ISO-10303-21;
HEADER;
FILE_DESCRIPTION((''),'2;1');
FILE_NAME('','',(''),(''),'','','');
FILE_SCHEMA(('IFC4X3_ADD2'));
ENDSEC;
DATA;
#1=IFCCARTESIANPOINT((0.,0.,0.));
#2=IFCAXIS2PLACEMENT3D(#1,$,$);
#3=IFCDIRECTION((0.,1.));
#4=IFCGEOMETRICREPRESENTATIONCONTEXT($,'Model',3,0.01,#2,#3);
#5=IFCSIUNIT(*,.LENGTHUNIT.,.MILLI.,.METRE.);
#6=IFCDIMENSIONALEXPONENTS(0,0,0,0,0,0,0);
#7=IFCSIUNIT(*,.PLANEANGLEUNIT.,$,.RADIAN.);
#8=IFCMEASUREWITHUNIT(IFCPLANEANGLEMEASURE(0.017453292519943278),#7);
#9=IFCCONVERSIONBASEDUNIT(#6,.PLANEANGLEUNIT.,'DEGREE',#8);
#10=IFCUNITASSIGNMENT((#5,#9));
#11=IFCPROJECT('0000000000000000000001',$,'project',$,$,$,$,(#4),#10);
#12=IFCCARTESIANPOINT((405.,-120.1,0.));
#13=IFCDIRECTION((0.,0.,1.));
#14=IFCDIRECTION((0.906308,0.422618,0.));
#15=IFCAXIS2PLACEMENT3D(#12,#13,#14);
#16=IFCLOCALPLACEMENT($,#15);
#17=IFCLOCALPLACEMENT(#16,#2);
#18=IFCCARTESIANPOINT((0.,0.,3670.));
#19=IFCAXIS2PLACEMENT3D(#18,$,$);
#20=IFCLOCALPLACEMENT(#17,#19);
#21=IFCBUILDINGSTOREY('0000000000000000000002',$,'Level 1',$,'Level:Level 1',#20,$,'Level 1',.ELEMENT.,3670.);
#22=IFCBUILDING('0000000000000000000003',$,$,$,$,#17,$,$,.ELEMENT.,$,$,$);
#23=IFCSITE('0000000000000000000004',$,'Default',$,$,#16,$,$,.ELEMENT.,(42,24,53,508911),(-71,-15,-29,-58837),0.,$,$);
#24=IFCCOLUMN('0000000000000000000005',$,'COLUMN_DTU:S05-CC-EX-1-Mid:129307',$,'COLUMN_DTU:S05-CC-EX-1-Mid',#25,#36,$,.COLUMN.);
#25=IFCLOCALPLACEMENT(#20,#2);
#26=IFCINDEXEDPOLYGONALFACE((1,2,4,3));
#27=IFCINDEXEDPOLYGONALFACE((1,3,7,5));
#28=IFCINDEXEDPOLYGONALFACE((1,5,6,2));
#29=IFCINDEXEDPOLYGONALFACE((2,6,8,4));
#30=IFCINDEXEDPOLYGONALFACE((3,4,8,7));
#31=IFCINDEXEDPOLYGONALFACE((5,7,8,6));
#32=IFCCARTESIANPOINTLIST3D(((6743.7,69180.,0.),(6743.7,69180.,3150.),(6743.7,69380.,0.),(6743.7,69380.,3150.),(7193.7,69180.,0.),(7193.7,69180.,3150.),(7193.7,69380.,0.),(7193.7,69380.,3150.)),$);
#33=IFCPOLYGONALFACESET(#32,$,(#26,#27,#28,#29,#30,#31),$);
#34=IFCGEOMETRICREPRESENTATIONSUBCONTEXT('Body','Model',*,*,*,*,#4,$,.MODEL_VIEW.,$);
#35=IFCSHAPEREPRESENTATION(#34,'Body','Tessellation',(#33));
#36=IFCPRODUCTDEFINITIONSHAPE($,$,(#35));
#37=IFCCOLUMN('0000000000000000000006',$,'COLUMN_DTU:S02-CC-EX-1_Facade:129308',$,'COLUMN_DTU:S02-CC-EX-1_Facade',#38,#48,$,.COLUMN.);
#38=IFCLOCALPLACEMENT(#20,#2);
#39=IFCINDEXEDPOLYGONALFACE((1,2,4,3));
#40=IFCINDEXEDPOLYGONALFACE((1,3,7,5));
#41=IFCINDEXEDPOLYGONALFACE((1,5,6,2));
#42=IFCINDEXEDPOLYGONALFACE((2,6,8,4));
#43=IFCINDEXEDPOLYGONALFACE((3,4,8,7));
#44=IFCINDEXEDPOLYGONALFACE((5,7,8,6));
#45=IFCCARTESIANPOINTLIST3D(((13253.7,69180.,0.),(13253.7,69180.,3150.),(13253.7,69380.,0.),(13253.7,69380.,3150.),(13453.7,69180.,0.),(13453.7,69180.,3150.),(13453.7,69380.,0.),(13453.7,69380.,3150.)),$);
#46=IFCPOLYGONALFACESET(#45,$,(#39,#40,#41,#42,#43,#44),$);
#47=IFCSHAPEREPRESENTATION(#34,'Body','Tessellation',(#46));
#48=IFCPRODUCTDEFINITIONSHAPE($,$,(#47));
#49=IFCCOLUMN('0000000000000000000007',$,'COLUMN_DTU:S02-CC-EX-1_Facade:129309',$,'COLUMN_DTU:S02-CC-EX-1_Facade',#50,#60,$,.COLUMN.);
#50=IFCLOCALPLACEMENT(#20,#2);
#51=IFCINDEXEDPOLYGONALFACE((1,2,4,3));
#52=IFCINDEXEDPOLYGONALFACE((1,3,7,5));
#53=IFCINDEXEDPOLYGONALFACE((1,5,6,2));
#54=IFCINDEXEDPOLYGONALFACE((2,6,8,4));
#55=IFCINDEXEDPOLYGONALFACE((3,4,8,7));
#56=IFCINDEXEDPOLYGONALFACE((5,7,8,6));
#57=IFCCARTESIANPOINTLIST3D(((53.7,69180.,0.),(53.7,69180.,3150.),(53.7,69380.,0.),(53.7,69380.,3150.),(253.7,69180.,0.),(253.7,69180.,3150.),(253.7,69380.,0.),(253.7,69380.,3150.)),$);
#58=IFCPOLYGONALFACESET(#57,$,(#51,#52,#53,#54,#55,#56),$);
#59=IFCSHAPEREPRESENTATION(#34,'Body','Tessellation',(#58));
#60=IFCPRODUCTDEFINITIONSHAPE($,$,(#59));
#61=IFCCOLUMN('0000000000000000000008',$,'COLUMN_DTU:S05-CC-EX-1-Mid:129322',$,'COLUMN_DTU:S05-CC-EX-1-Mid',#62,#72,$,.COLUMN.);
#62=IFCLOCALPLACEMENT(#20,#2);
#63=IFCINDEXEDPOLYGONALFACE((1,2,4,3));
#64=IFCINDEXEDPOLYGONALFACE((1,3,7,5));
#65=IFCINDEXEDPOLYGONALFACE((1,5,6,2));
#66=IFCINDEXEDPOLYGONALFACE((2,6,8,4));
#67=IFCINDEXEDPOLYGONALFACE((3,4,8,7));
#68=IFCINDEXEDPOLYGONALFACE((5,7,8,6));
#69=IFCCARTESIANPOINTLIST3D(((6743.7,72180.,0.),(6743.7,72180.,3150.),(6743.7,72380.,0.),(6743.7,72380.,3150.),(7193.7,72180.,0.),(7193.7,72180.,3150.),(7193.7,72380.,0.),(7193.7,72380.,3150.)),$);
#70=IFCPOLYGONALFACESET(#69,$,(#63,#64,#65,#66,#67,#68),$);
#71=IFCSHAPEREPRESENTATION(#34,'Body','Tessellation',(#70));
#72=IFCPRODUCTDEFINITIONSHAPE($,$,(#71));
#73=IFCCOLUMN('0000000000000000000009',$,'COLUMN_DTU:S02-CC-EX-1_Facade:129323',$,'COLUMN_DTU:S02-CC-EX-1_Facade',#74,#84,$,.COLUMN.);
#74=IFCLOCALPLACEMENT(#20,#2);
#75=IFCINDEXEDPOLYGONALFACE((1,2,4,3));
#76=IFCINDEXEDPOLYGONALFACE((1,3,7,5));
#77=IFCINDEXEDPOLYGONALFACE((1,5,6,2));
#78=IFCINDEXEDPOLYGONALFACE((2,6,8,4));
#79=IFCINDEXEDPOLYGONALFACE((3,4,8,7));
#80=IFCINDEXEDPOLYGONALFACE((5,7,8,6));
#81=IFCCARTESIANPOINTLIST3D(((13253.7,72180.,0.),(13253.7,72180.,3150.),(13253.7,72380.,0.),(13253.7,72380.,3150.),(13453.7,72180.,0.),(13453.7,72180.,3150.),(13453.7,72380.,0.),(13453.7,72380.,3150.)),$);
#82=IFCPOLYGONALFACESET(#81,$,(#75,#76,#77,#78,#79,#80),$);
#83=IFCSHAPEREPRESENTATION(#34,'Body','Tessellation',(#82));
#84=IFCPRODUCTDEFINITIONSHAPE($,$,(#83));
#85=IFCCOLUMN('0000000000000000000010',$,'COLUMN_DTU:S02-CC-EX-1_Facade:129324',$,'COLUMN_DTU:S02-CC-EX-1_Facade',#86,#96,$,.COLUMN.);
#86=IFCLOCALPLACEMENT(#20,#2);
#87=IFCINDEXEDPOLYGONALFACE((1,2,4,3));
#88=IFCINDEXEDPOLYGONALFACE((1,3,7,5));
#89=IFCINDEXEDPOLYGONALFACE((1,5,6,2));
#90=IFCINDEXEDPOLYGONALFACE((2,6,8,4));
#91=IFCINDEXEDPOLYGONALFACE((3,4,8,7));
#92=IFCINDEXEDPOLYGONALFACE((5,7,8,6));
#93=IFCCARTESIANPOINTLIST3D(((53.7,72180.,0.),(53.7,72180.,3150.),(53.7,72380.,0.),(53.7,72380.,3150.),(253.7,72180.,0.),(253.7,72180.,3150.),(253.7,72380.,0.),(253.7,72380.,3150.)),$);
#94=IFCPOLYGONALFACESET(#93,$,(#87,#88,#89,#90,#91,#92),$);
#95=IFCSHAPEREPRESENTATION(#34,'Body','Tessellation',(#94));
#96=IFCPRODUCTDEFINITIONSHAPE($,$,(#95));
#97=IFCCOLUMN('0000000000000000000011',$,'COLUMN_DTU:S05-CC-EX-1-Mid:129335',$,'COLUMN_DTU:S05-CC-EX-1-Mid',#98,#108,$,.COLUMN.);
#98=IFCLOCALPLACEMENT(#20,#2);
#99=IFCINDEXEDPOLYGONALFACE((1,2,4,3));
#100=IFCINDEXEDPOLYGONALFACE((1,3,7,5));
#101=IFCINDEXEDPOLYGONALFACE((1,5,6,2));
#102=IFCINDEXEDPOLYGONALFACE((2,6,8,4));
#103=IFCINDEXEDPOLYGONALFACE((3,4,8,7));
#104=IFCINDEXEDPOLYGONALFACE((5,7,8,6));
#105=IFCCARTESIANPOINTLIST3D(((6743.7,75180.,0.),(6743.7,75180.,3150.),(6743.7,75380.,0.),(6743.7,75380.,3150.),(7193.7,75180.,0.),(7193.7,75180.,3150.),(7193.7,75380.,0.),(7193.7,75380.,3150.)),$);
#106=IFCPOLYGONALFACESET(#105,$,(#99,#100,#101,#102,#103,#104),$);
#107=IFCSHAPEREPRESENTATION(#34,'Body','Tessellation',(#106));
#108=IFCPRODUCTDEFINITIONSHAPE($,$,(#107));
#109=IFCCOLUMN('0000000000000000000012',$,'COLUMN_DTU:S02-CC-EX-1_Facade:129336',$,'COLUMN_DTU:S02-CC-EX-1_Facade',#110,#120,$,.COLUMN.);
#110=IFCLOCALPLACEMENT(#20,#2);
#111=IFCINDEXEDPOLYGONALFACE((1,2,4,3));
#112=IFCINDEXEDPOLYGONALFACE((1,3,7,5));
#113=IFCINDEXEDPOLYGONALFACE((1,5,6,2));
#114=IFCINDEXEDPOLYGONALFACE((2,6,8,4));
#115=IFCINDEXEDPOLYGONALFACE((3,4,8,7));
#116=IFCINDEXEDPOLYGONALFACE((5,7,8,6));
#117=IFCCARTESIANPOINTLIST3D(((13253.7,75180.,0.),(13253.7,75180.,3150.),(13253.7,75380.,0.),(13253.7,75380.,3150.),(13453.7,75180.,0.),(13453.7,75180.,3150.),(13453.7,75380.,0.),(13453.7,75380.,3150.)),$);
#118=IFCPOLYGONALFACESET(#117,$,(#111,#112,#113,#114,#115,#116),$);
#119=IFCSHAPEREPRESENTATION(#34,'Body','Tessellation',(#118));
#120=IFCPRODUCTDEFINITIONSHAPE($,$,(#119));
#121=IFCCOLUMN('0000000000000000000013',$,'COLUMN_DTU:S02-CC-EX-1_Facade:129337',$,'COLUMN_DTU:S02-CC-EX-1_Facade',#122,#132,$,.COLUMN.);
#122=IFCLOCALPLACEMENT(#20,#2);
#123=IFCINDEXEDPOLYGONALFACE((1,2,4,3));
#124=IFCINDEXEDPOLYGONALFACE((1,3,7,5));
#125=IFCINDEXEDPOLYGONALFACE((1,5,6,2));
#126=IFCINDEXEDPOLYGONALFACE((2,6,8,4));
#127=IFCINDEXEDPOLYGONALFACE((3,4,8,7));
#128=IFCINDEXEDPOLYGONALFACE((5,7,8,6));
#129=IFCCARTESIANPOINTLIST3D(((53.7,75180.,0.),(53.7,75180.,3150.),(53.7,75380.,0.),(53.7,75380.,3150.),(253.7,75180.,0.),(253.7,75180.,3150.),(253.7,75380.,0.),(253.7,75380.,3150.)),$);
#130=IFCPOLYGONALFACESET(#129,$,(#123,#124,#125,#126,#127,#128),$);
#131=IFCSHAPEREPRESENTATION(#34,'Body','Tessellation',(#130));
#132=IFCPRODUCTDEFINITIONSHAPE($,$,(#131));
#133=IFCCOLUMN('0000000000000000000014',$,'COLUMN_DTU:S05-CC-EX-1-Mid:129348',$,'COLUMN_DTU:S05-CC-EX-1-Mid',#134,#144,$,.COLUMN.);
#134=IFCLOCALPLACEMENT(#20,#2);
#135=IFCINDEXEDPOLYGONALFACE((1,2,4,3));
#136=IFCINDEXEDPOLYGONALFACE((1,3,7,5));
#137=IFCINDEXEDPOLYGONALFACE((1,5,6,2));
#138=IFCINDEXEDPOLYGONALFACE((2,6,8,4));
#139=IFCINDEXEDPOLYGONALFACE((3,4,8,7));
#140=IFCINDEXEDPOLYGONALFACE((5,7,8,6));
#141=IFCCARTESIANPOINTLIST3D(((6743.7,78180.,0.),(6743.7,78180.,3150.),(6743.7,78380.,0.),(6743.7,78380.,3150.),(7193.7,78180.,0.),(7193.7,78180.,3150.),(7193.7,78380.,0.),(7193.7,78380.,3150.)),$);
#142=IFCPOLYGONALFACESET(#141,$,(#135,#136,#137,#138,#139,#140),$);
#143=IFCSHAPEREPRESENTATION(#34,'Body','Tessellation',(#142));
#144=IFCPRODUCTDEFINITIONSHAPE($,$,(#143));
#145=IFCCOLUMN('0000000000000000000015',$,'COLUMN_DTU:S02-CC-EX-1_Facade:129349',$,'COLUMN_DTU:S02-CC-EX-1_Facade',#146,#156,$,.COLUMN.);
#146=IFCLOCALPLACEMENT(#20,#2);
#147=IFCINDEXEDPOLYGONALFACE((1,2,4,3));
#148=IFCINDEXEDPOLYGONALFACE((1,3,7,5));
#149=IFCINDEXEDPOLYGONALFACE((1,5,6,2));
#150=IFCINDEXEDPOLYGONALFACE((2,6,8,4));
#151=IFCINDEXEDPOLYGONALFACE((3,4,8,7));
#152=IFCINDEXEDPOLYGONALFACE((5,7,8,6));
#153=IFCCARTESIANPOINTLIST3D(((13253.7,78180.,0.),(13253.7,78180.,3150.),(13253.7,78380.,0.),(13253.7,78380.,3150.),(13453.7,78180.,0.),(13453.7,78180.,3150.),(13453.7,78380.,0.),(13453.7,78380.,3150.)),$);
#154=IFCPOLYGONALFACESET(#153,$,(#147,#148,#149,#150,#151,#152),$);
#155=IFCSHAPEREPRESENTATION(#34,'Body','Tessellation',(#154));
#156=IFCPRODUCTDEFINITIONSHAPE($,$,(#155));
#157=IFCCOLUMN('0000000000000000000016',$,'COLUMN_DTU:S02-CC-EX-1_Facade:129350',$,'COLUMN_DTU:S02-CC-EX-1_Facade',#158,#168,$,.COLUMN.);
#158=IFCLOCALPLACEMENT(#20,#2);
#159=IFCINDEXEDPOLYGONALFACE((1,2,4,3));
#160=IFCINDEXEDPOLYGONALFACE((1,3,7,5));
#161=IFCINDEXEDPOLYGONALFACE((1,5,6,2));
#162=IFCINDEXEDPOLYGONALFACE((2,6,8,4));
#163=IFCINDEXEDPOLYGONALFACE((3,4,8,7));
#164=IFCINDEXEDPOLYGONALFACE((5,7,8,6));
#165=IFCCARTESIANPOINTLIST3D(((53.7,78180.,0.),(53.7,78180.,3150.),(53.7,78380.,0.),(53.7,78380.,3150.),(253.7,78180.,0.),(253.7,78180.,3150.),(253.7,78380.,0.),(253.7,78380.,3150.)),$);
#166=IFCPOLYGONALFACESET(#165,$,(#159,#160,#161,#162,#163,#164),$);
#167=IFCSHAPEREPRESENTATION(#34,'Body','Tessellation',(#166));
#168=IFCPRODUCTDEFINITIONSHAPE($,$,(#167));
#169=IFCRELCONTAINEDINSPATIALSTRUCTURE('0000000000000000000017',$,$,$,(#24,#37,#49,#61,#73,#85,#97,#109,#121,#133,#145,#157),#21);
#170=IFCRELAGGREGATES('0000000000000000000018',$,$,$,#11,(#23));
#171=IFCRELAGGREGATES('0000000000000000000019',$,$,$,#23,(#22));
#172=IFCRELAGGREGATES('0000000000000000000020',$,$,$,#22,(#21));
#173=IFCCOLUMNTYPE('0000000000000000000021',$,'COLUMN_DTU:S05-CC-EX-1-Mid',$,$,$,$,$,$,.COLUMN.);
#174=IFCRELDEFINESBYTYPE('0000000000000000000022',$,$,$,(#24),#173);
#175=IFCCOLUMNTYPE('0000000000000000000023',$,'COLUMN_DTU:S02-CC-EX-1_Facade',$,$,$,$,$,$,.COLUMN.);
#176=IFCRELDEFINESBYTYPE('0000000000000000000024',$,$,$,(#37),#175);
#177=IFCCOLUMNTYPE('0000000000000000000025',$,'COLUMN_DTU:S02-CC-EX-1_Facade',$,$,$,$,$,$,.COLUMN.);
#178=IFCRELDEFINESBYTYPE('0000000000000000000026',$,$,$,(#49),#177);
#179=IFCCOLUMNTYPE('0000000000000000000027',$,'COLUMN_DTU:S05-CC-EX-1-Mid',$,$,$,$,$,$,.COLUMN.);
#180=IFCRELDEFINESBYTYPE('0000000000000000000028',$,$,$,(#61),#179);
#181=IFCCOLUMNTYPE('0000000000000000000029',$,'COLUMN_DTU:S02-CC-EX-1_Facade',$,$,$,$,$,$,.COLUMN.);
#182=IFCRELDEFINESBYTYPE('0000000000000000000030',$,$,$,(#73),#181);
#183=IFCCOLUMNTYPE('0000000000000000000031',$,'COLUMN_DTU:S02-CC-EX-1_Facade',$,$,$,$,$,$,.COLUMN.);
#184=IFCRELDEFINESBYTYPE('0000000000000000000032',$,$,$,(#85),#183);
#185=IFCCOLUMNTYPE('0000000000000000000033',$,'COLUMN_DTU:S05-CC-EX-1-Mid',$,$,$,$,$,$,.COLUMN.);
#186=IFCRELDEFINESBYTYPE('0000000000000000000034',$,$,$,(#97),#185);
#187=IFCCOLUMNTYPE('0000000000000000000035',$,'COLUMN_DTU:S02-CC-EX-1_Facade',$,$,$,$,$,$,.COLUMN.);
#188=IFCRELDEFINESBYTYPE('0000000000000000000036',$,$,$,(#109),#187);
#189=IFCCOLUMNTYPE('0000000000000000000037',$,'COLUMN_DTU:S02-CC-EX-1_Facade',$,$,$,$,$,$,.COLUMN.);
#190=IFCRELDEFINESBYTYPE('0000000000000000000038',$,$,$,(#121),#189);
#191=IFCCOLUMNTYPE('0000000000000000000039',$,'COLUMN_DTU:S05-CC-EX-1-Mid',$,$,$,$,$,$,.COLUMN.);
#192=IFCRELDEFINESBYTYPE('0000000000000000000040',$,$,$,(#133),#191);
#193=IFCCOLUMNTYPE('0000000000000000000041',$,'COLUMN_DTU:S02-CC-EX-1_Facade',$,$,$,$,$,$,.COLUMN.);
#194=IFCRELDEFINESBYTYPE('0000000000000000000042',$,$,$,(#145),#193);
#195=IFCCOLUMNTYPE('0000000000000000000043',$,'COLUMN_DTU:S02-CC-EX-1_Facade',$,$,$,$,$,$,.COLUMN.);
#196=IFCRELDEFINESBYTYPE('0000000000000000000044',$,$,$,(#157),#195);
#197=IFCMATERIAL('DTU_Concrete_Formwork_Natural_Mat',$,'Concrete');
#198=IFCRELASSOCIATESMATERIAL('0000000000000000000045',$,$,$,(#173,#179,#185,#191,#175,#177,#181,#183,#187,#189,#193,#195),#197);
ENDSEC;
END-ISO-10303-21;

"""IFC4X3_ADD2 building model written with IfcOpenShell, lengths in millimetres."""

from ifc_helpers import new_model, entity, si_unit, converted_unit, direction, frame, frame_2d, origin, origin_2d_with_axis, place, context, subcontext, project, spatial, rectangle, extrude, source, transform, mapped, material, material_profile, profile_set, type_object, type_shapes, element, save


model = new_model("IFC4X3_ADD2")

# Units and contexts
model_context = context("Model", 3, precision=0.01, world=origin(), true_north=direction((0.0, 1.0)))
body_context = subcontext(model_context, "Body", "Model", "MODEL_VIEW")
ifc_project = project(units=[si_unit("LENGTHUNIT", "METRE", prefix="MILLI"), converted_unit("PLANEANGLEUNIT", "DEGREE", entity("IfcPlaneAngleMeasure", 0.017453292519943278), si_unit("PLANEANGLEUNIT", "RADIAN"), dimensions=[0, 0, 0, 0, 0, 0, 0])], contexts=[model_context])

# Site, building, storey
site_placement = place(None, frame((405.0, -120.1, 0.0), z_axis=(0.0, 0.0, 1.0), x_axis=(0.906308, 0.422618, 0.0)))
site = spatial("IfcSite", under=ifc_project, at=site_placement, Name="Default", CompositionType="ELEMENT", RefLatitude=(42, 24, 53, 508911), RefLongitude=(-71, -15, -29, -58837), RefElevation=0.0)
building_placement = place(site_placement, origin())
building = spatial("IfcBuilding", under=site, at=building_placement, CompositionType="ELEMENT")
storey_placement = place(building_placement, frame((0.0, 0.0, 3670.0)))
storey = spatial("IfcBuildingStorey", under=building, at=storey_placement, Name="Level 1", ObjectType="Level:Level 1", LongName="Level 1", CompositionType="ELEMENT", Elevation=3670.0)

# Columns
ifc_material = material(Name="DTU_Concrete_Formwork_Natural_Mat", Category="Concrete")
ifc_material_profile_1 = material_profile(ifc_material, rectangle(XDim=200.0, YDim=450.0, at=origin_2d_with_axis()), Name="S05-CC-EX-1-Mid")
ifc_profile_set_1 = profile_set([ifc_material_profile_1], Name="S05-CC-EX-1-Mid")
column_type_1 = type_object("IfcColumnType", Name="COLUMN_DTU:S05-CC-EX-1-Mid", PredefinedType="COLUMN", material=ifc_profile_set_1)
shared_shape_1 = source(origin(), body_context, "Body", "SweptSolid", [
    extrude(rectangle(XDim=200.0, YDim=450.0, at=frame_2d((0.0, 0.0), x_axis=(1.0, 0.0))), frame((6968.7, 69280.0, 3670.0), z_axis=(0.0, 0.0, 1.0), x_axis=(0.0, 1.0, 0.0)), (0.0, 0.0, 1.0), 3150.0),
])
type_shapes(column_type_1, [shared_shape_1])
column_1_placement = place(storey_placement, frame((0.0, 0.0, -3670.0)))
element("IfcColumn", 1, at=column_1_placement, inside=storey, type_object=column_type_1, Name="COLUMN_DTU:S05-CC-EX-1-Mid:129307", ObjectType="COLUMN_DTU:S05-CC-EX-1-Mid", PredefinedType="COLUMN", context=body_context, shape_type="MappedRepresentation", body=[
    mapped(shared_shape_1, transform((0.0, 0.0, 0.0), scale=1.0)),
])
ifc_material_profile_2 = material_profile(ifc_material, rectangle(XDim=200.0, YDim=200.0, at=frame_2d((0.0, 0.0), x_axis=(1.0, 0.0))), Name="S02-CC-EX-1_Facade")
ifc_profile_set_2 = profile_set([ifc_material_profile_2], Name="S02-CC-EX-1_Facade")
column_type_2 = type_object("IfcColumnType", Name="COLUMN_DTU:S02-CC-EX-1_Facade", PredefinedType="COLUMN", material=ifc_profile_set_2)
shared_shape_2 = source(origin(), body_context, "Body", "SweptSolid", [
    extrude(rectangle(XDim=200.0, YDim=200.0, at=frame_2d((0.0, 0.0), x_axis=(1.0, 0.0))), frame((13353.7, 69280.0, 3670.0), z_axis=(0.0, 0.0, 1.0), x_axis=(0.0, -1.0, 0.0)), (0.0, 0.0, 1.0), 3150.0),
])
type_shapes(column_type_2, [shared_shape_2])
column_2_placement = place(storey_placement, frame((0.0, 0.0, -3670.0)))
element("IfcColumn", 2, at=column_2_placement, inside=storey, type_object=column_type_2, Name="COLUMN_DTU:S02-CC-EX-1_Facade:129308", ObjectType="COLUMN_DTU:S02-CC-EX-1_Facade", PredefinedType="COLUMN", context=body_context, shape_type="MappedRepresentation", body=[
    mapped(shared_shape_2, transform((0.0, 0.0, 0.0), scale=1.0)),
])
column_type_3 = type_object("IfcColumnType", Name="COLUMN_DTU:S02-CC-EX-1_Facade", PredefinedType="COLUMN", material=ifc_profile_set_2)
shared_shape_3 = source(origin(), body_context, "Body", "SweptSolid", [
    extrude(rectangle(XDim=200.0, YDim=200.0, at=frame_2d((0.0, 0.0), x_axis=(1.0, 0.0))), frame((153.7, 69280.0, 3670.0), z_axis=(0.0, 0.0, 1.0), x_axis=(0.0, -1.0, 0.0)), (0.0, 0.0, 1.0), 3150.0),
])
type_shapes(column_type_3, [shared_shape_3])
column_3_placement = place(storey_placement, frame((0.0, 0.0, -3670.0)))
element("IfcColumn", 3, at=column_3_placement, inside=storey, type_object=column_type_3, Name="COLUMN_DTU:S02-CC-EX-1_Facade:129309", ObjectType="COLUMN_DTU:S02-CC-EX-1_Facade", PredefinedType="COLUMN", context=body_context, shape_type="MappedRepresentation", body=[
    mapped(shared_shape_3, transform((0.0, 0.0, 0.0), scale=1.0)),
])
column_type_4 = type_object("IfcColumnType", Name="COLUMN_DTU:S05-CC-EX-1-Mid", PredefinedType="COLUMN", material=ifc_profile_set_1)
shared_shape_4 = source(origin(), body_context, "Body", "SweptSolid", [
    extrude(rectangle(XDim=200.0, YDim=450.0, at=frame_2d((0.0, 0.0), x_axis=(1.0, 0.0))), frame((6968.7, 72280.0, 3670.0), z_axis=(0.0, 0.0, 1.0), x_axis=(0.0, 1.0, 0.0)), (0.0, 0.0, 1.0), 3150.0),
])
type_shapes(column_type_4, [shared_shape_4])
column_4_placement = place(storey_placement, frame((0.0, 0.0, -3670.0)))
element("IfcColumn", 4, at=column_4_placement, inside=storey, type_object=column_type_4, Name="COLUMN_DTU:S05-CC-EX-1-Mid:129322", ObjectType="COLUMN_DTU:S05-CC-EX-1-Mid", PredefinedType="COLUMN", context=body_context, shape_type="MappedRepresentation", body=[
    mapped(shared_shape_4, transform((0.0, 0.0, 0.0), scale=1.0)),
])
column_type_5 = type_object("IfcColumnType", Name="COLUMN_DTU:S02-CC-EX-1_Facade", PredefinedType="COLUMN", material=ifc_profile_set_2)
shared_shape_5 = source(origin(), body_context, "Body", "SweptSolid", [
    extrude(rectangle(XDim=200.0, YDim=200.0, at=frame_2d((0.0, 0.0), x_axis=(1.0, 0.0))), frame((13353.7, 72280.0, 3670.0), z_axis=(0.0, 0.0, 1.0), x_axis=(0.0, -1.0, 0.0)), (0.0, 0.0, 1.0), 3150.0),
])
type_shapes(column_type_5, [shared_shape_5])
column_5_placement = place(storey_placement, frame((0.0, 0.0, -3670.0)))
element("IfcColumn", 5, at=column_5_placement, inside=storey, type_object=column_type_5, Name="COLUMN_DTU:S02-CC-EX-1_Facade:129323", ObjectType="COLUMN_DTU:S02-CC-EX-1_Facade", PredefinedType="COLUMN", context=body_context, shape_type="MappedRepresentation", body=[
    mapped(shared_shape_5, transform((0.0, 0.0, 0.0), scale=1.0)),
])
column_type_6 = type_object("IfcColumnType", Name="COLUMN_DTU:S02-CC-EX-1_Facade", PredefinedType="COLUMN", material=ifc_profile_set_2)
shared_shape_6 = source(origin(), body_context, "Body", "SweptSolid", [
    extrude(rectangle(XDim=200.0, YDim=200.0, at=frame_2d((0.0, 0.0), x_axis=(1.0, 0.0))), frame((153.7, 72280.0, 3670.0), z_axis=(0.0, 0.0, 1.0), x_axis=(0.0, -1.0, 0.0)), (0.0, 0.0, 1.0), 3150.0),
])
type_shapes(column_type_6, [shared_shape_6])
column_6_placement = place(storey_placement, frame((0.0, 0.0, -3670.0)))
element("IfcColumn", 6, at=column_6_placement, inside=storey, type_object=column_type_6, Name="COLUMN_DTU:S02-CC-EX-1_Facade:129324", ObjectType="COLUMN_DTU:S02-CC-EX-1_Facade", PredefinedType="COLUMN", context=body_context, shape_type="MappedRepresentation", body=[
    mapped(shared_shape_6, transform((0.0, 0.0, 0.0), scale=1.0)),
])
column_type_7 = type_object("IfcColumnType", Name="COLUMN_DTU:S05-CC-EX-1-Mid", PredefinedType="COLUMN", material=ifc_profile_set_1)
shared_shape_7 = source(origin(), body_context, "Body", "SweptSolid", [
    extrude(rectangle(XDim=200.0, YDim=450.0, at=frame_2d((0.0, 0.0), x_axis=(1.0, 0.0))), frame((6968.7, 75280.0, 3670.0), z_axis=(0.0, 0.0, 1.0), x_axis=(0.0, 1.0, 0.0)), (0.0, 0.0, 1.0), 3150.0),
])
type_shapes(column_type_7, [shared_shape_7])
column_7_placement = place(storey_placement, frame((0.0, 0.0, -3670.0)))
element("IfcColumn", 7, at=column_7_placement, inside=storey, type_object=column_type_7, Name="COLUMN_DTU:S05-CC-EX-1-Mid:129335", ObjectType="COLUMN_DTU:S05-CC-EX-1-Mid", PredefinedType="COLUMN", context=body_context, shape_type="MappedRepresentation", body=[
    mapped(shared_shape_7, transform((0.0, 0.0, 0.0), scale=1.0)),
])
column_type_8 = type_object("IfcColumnType", Name="COLUMN_DTU:S02-CC-EX-1_Facade", PredefinedType="COLUMN", material=ifc_profile_set_2)
shared_shape_8 = source(origin(), body_context, "Body", "SweptSolid", [
    extrude(rectangle(XDim=200.0, YDim=200.0, at=frame_2d((0.0, 0.0), x_axis=(1.0, 0.0))), frame((13353.7, 75280.0, 3670.0), z_axis=(0.0, 0.0, 1.0), x_axis=(0.0, -1.0, 0.0)), (0.0, 0.0, 1.0), 3150.0),
])
type_shapes(column_type_8, [shared_shape_8])
column_8_placement = place(storey_placement, frame((0.0, 0.0, -3670.0)))
element("IfcColumn", 8, at=column_8_placement, inside=storey, type_object=column_type_8, Name="COLUMN_DTU:S02-CC-EX-1_Facade:129336", ObjectType="COLUMN_DTU:S02-CC-EX-1_Facade", PredefinedType="COLUMN", context=body_context, shape_type="MappedRepresentation", body=[
    mapped(shared_shape_8, transform((0.0, 0.0, 0.0), scale=1.0)),
])
column_type_9 = type_object("IfcColumnType", Name="COLUMN_DTU:S02-CC-EX-1_Facade", PredefinedType="COLUMN", material=ifc_profile_set_2)
shared_shape_9 = source(origin(), body_context, "Body", "SweptSolid", [
    extrude(rectangle(XDim=200.0, YDim=200.0, at=frame_2d((0.0, 0.0), x_axis=(1.0, 0.0))), frame((153.7, 75280.0, 3670.0), z_axis=(0.0, 0.0, 1.0), x_axis=(0.0, -1.0, 0.0)), (0.0, 0.0, 1.0), 3150.0),
])
type_shapes(column_type_9, [shared_shape_9])
column_9_placement = place(storey_placement, frame((0.0, 0.0, -3670.0)))
element("IfcColumn", 9, at=column_9_placement, inside=storey, type_object=column_type_9, Name="COLUMN_DTU:S02-CC-EX-1_Facade:129337", ObjectType="COLUMN_DTU:S02-CC-EX-1_Facade", PredefinedType="COLUMN", context=body_context, shape_type="MappedRepresentation", body=[
    mapped(shared_shape_9, transform((0.0, 0.0, 0.0), scale=1.0)),
])
column_type_10 = type_object("IfcColumnType", Name="COLUMN_DTU:S05-CC-EX-1-Mid", PredefinedType="COLUMN", material=ifc_profile_set_1)
shared_shape_10 = source(origin(), body_context, "Body", "SweptSolid", [
    extrude(rectangle(XDim=200.0, YDim=450.0, at=frame_2d((0.0, 0.0), x_axis=(1.0, 0.0))), frame((6968.7, 78280.0, 3670.0), z_axis=(0.0, 0.0, 1.0), x_axis=(0.0, 1.0, 0.0)), (0.0, 0.0, 1.0), 3150.0),
])
type_shapes(column_type_10, [shared_shape_10])
column_10_placement = place(storey_placement, frame((0.0, 0.0, -3670.0)))
element("IfcColumn", 10, at=column_10_placement, inside=storey, type_object=column_type_10, Name="COLUMN_DTU:S05-CC-EX-1-Mid:129348", ObjectType="COLUMN_DTU:S05-CC-EX-1-Mid", PredefinedType="COLUMN", context=body_context, shape_type="MappedRepresentation", body=[
    mapped(shared_shape_10, transform((0.0, 0.0, 0.0), scale=1.0)),
])
column_type_11 = type_object("IfcColumnType", Name="COLUMN_DTU:S02-CC-EX-1_Facade", PredefinedType="COLUMN", material=ifc_profile_set_2)
shared_shape_11 = source(origin(), body_context, "Body", "SweptSolid", [
    extrude(rectangle(XDim=200.0, YDim=200.0, at=frame_2d((0.0, 0.0), x_axis=(1.0, 0.0))), frame((13353.7, 78280.0, 3670.0), z_axis=(0.0, 0.0, 1.0), x_axis=(0.0, -1.0, 0.0)), (0.0, 0.0, 1.0), 3150.0),
])
type_shapes(column_type_11, [shared_shape_11])
column_11_placement = place(storey_placement, frame((0.0, 0.0, -3670.0)))
element("IfcColumn", 11, at=column_11_placement, inside=storey, type_object=column_type_11, Name="COLUMN_DTU:S02-CC-EX-1_Facade:129349", ObjectType="COLUMN_DTU:S02-CC-EX-1_Facade", PredefinedType="COLUMN", context=body_context, shape_type="MappedRepresentation", body=[
    mapped(shared_shape_11, transform((0.0, 0.0, 0.0), scale=1.0)),
])
column_type_12 = type_object("IfcColumnType", Name="COLUMN_DTU:S02-CC-EX-1_Facade", PredefinedType="COLUMN", material=ifc_profile_set_2)
shared_shape_12 = source(origin(), body_context, "Body", "SweptSolid", [
    extrude(rectangle(XDim=200.0, YDim=200.0, at=frame_2d((0.0, 0.0), x_axis=(1.0, 0.0))), frame((153.7, 78280.0, 3670.0), z_axis=(0.0, 0.0, 1.0), x_axis=(0.0, -1.0, 0.0)), (0.0, 0.0, 1.0), 3150.0),
])
type_shapes(column_type_12, [shared_shape_12])
column_12_placement = place(storey_placement, frame((0.0, 0.0, -3670.0)))
element("IfcColumn", 12, at=column_12_placement, inside=storey, type_object=column_type_12, Name="COLUMN_DTU:S02-CC-EX-1_Facade:129350", ObjectType="COLUMN_DTU:S02-CC-EX-1_Facade", PredefinedType="COLUMN", context=body_context, shape_type="MappedRepresentation", body=[
    mapped(shared_shape_12, transform((0.0, 0.0, 0.0), scale=1.0)),
])

save(model, "model.ifc")
